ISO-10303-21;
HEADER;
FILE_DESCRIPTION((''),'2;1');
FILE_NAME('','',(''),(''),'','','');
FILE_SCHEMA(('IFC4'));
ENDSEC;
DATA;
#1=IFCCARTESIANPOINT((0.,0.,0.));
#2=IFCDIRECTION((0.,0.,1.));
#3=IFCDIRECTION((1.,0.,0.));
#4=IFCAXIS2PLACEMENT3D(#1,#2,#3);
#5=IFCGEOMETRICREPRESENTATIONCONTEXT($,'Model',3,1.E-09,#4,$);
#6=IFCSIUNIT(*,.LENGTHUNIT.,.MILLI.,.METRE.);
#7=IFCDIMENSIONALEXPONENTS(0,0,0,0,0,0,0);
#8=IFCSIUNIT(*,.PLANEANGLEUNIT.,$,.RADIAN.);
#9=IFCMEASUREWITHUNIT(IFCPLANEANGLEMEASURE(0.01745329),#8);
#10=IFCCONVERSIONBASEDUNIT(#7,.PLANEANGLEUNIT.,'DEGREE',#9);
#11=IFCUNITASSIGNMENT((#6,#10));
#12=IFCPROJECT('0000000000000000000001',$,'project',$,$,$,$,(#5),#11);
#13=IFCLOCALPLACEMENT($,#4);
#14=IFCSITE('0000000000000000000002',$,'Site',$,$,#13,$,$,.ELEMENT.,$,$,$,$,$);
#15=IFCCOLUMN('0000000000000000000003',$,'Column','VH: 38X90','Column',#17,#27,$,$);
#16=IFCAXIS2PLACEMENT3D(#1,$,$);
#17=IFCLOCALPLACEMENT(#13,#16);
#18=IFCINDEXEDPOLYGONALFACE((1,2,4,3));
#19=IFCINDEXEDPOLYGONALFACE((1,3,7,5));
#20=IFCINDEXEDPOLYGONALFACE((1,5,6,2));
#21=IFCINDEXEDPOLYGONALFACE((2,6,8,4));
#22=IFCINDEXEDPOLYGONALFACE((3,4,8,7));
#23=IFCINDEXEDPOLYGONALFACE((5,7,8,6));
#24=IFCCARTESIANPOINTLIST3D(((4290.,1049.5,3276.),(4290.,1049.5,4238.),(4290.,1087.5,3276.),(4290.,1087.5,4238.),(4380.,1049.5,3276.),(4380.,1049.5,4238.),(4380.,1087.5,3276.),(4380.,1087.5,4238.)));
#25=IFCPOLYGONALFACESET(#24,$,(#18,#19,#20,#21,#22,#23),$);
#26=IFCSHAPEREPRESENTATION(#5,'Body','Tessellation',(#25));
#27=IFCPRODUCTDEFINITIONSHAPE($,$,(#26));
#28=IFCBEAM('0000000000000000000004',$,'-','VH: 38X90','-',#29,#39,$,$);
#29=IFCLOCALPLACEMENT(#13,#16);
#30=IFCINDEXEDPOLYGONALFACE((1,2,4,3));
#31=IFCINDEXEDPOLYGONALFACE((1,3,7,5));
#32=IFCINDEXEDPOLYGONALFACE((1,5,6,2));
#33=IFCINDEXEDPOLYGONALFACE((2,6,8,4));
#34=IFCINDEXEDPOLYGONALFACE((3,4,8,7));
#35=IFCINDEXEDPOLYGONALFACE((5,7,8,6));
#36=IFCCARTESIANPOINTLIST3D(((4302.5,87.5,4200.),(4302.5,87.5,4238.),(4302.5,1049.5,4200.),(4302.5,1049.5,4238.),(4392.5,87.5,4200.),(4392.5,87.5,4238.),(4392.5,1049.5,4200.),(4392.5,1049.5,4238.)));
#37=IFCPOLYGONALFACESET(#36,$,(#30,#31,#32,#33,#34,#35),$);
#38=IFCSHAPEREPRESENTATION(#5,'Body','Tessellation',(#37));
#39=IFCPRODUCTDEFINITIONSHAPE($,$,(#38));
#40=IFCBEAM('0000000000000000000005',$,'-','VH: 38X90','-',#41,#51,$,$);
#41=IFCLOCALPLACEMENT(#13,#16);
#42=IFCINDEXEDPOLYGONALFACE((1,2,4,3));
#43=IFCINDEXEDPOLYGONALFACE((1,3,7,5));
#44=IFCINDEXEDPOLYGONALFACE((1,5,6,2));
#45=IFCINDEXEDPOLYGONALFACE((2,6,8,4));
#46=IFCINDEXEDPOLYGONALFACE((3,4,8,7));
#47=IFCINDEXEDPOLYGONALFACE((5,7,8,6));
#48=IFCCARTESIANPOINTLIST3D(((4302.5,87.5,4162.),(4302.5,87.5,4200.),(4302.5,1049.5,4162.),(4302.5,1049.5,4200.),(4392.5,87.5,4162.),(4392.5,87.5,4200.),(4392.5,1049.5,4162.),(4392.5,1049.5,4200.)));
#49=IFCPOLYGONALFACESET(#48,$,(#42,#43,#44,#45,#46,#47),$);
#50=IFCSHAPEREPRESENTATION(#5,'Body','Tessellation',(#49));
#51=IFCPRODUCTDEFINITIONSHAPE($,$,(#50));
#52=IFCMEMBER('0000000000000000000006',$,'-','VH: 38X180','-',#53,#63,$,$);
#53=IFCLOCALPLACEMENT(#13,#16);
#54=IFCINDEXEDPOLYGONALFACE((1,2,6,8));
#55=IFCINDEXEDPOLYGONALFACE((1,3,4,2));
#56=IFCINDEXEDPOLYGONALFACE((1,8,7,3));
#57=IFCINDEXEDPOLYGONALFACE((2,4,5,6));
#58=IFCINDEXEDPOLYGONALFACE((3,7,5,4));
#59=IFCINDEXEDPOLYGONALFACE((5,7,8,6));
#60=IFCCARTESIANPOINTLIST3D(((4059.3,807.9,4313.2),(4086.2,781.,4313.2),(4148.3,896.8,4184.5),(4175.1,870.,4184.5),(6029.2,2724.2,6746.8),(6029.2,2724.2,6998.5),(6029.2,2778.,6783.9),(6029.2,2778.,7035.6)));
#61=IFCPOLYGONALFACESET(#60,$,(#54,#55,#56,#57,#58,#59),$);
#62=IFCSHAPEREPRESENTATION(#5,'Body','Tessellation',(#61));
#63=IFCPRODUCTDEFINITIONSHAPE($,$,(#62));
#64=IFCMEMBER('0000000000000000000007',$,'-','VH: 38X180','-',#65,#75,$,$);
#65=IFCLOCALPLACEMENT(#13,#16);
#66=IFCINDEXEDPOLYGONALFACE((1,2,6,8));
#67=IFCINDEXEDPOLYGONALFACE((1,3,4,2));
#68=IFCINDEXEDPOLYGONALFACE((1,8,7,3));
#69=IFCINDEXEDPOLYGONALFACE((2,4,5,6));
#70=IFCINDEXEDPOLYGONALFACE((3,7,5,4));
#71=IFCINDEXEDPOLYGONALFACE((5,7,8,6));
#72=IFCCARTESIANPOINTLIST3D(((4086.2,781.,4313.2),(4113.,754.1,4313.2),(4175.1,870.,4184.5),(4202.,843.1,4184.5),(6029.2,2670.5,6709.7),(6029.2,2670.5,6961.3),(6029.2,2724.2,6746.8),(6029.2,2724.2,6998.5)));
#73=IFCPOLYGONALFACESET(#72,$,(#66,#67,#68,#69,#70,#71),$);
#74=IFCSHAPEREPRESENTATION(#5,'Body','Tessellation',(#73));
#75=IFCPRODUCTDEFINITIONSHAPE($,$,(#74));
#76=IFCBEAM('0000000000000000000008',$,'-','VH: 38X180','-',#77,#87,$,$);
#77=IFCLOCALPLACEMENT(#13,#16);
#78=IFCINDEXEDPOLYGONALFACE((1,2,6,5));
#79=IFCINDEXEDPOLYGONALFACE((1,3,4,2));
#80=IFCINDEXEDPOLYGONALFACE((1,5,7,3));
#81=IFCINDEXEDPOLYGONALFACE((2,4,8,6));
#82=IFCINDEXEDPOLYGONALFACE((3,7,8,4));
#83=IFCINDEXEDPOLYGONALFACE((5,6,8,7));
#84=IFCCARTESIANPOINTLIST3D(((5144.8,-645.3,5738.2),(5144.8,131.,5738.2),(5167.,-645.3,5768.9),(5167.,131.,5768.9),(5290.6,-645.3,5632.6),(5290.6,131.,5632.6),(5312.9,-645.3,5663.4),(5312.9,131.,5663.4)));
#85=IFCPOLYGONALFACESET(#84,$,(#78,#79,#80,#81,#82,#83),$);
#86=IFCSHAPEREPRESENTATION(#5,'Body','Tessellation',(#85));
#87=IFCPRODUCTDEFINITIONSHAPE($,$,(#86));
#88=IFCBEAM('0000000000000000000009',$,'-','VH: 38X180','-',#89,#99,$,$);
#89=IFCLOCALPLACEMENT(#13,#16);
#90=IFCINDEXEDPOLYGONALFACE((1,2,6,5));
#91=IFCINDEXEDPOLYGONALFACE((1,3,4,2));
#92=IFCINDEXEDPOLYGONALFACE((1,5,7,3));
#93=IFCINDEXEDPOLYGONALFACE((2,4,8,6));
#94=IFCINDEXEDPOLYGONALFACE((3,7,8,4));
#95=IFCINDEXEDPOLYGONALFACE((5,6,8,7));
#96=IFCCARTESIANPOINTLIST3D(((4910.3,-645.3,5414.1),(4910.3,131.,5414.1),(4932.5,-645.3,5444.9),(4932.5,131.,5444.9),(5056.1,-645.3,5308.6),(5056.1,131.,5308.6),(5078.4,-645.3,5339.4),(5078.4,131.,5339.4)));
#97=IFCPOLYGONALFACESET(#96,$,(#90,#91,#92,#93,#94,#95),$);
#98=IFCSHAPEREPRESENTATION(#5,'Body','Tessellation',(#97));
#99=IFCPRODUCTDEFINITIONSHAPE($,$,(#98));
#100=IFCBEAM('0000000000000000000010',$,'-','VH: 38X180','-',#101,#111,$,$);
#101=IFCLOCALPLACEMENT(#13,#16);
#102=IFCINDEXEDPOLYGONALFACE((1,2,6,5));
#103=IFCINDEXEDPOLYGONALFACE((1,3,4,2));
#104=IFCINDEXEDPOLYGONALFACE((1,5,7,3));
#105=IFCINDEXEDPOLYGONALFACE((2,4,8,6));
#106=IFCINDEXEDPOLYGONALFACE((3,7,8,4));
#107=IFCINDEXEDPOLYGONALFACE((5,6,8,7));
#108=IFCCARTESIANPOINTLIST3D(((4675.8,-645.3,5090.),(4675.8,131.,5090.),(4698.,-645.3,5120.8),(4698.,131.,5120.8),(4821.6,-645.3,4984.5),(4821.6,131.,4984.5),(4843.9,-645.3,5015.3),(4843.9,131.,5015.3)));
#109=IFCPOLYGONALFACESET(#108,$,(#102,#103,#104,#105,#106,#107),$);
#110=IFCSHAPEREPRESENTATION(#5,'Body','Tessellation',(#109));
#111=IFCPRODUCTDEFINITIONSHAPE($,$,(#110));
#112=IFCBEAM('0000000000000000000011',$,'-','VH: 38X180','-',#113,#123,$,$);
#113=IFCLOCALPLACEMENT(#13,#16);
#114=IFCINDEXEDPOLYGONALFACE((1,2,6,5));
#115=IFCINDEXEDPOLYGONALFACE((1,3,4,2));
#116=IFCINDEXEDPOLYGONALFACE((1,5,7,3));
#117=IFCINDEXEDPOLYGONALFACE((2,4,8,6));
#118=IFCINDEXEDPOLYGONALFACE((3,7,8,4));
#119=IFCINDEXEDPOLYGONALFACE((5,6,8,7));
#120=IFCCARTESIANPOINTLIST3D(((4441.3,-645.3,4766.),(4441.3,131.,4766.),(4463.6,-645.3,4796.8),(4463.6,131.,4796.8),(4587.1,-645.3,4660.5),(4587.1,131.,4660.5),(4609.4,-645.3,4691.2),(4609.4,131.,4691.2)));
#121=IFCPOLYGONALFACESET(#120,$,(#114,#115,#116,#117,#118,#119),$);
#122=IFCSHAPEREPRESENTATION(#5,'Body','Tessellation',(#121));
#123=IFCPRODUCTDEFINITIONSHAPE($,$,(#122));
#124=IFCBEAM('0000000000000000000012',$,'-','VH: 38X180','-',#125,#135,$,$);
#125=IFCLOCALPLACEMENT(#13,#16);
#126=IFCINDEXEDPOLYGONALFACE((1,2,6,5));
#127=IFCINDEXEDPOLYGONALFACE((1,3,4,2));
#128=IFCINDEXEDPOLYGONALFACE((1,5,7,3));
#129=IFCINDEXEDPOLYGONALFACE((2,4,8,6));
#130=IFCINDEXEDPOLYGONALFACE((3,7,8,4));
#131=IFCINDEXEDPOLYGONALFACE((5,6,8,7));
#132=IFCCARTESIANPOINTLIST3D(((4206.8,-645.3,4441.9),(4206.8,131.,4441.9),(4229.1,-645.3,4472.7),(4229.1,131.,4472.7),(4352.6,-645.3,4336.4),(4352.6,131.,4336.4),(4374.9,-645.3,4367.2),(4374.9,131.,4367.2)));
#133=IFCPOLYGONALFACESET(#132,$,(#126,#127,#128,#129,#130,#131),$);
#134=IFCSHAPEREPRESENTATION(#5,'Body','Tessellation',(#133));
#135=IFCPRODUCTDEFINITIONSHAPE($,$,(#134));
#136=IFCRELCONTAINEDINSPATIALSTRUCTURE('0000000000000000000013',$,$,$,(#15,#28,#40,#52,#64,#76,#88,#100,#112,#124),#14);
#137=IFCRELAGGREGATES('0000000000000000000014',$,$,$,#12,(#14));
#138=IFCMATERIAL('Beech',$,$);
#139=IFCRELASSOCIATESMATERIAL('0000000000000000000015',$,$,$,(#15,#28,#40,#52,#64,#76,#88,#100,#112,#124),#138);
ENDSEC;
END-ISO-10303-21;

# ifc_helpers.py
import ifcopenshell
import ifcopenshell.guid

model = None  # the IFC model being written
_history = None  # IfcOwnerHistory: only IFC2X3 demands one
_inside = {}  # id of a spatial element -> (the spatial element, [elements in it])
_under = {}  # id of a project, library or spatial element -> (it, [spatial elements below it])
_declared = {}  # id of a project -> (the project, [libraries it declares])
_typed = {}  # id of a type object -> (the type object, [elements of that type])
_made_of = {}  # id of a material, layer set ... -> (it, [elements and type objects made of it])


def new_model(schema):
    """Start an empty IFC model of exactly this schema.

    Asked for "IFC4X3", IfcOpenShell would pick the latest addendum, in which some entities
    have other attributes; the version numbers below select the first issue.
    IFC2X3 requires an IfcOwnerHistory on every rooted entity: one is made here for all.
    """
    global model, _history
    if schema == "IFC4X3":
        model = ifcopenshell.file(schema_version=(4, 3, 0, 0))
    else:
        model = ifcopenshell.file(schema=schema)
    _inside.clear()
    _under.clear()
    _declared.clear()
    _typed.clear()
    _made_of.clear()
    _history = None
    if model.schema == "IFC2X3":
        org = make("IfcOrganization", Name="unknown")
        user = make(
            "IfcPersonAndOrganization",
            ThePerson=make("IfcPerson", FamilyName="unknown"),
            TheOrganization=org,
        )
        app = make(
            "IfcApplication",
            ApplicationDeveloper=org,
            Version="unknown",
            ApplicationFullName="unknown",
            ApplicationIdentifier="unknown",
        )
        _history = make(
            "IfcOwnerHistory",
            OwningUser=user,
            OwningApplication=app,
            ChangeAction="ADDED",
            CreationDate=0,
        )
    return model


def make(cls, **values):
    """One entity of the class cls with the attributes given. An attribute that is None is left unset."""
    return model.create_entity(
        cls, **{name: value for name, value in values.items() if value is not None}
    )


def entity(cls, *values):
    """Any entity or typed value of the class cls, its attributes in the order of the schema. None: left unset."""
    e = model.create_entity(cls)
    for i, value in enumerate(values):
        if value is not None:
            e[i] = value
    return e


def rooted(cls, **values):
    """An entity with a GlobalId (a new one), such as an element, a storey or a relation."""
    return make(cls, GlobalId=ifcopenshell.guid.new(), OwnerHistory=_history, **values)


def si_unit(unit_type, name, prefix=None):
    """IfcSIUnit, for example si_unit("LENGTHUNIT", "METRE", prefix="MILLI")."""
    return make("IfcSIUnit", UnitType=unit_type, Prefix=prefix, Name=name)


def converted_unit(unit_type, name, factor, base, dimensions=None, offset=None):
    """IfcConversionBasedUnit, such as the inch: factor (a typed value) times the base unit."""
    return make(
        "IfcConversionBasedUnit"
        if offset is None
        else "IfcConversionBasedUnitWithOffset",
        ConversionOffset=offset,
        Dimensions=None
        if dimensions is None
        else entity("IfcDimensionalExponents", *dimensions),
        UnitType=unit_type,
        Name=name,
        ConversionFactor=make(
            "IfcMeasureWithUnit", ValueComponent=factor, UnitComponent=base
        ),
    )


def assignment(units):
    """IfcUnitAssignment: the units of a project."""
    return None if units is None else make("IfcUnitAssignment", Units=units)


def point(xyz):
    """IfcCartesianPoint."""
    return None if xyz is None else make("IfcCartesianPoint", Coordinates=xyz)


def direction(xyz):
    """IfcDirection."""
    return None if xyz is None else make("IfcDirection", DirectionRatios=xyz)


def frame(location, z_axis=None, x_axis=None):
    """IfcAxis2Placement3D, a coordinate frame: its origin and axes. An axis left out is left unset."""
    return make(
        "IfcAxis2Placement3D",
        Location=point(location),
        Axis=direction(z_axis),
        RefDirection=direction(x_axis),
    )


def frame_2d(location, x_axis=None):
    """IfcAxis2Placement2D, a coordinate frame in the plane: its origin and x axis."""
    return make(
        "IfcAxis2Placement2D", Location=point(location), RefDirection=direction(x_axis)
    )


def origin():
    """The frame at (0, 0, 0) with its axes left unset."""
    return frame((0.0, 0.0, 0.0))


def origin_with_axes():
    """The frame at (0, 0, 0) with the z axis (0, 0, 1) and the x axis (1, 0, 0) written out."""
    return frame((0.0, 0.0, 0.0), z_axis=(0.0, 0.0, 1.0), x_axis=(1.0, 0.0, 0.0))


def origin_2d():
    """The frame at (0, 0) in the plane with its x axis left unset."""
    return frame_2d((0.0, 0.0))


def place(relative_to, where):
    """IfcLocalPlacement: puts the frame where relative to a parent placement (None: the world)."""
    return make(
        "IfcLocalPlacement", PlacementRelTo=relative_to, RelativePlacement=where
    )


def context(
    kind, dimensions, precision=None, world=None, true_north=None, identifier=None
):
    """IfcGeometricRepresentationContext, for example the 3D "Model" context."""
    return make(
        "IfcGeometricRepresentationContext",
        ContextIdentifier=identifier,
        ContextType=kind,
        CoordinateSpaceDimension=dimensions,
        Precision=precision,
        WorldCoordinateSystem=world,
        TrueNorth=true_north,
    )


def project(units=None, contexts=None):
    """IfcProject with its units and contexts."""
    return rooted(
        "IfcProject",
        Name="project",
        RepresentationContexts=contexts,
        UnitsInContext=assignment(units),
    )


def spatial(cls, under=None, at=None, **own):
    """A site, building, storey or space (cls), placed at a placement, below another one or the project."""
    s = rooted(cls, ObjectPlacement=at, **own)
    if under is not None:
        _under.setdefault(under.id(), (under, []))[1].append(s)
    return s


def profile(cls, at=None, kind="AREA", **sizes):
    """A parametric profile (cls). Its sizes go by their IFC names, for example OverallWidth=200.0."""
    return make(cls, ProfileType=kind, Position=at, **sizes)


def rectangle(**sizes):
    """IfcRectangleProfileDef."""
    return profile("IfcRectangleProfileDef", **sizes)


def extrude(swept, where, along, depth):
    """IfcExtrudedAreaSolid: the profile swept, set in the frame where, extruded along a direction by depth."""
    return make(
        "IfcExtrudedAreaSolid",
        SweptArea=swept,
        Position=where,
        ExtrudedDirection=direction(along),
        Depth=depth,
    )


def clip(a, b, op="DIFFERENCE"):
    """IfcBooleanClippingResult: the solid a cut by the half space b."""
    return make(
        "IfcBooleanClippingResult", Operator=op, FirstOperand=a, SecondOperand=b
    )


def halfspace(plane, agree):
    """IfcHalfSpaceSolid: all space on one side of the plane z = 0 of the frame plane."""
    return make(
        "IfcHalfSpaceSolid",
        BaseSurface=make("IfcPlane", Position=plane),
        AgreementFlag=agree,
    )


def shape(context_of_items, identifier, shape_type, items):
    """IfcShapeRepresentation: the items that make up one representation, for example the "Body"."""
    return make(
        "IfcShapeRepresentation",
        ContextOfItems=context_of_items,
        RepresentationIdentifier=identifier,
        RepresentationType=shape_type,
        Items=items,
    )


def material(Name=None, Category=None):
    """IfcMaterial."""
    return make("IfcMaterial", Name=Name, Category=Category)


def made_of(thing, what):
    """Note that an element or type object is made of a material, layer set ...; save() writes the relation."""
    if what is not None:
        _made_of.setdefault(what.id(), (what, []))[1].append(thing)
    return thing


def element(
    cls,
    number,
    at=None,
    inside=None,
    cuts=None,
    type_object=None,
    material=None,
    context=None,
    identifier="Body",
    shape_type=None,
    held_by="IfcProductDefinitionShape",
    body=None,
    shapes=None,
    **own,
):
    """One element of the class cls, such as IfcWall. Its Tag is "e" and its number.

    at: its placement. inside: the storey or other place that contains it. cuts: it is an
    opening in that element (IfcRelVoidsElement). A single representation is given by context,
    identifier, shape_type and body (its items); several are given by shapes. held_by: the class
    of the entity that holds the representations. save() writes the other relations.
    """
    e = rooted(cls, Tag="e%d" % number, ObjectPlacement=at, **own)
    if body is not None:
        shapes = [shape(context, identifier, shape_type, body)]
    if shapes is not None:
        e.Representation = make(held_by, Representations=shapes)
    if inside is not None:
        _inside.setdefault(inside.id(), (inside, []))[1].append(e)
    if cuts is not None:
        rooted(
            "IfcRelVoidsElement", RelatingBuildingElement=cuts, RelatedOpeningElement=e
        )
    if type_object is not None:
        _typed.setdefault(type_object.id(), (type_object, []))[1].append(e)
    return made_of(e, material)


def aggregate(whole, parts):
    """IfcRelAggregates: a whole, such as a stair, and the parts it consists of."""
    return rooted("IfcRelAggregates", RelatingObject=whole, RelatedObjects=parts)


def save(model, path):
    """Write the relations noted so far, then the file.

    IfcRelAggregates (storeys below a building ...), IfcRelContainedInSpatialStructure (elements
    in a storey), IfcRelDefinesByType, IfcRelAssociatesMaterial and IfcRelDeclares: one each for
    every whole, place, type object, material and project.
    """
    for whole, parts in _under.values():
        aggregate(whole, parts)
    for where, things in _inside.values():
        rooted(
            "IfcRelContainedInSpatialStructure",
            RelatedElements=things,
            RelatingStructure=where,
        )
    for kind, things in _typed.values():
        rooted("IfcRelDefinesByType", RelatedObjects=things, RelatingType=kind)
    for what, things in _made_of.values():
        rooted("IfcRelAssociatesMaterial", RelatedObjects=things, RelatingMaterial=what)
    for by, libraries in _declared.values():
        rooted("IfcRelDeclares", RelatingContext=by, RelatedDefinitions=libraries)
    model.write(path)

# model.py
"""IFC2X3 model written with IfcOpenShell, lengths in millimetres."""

from ifc_helpers import new_model, entity, si_unit, converted_unit, frame, origin, origin_with_axes, origin_2d, place, context, project, spatial, rectangle, extrude, clip, halfspace, material, element, save


model = new_model("IFC2X3")

# Units and contexts
model_context = context("Model", 3, precision=1e-09, world=origin_with_axes())
ifc_project = project(units=[si_unit("LENGTHUNIT", "METRE", prefix="MILLI"), converted_unit("PLANEANGLEUNIT", "DEGREE", entity("IfcPlaneAngleMeasure", 0.01745329), si_unit("PLANEANGLEUNIT", "RADIAN"), dimensions=[0, 0, 0, 0, 0, 0, 0])], contexts=[model_context])

# Site
site_placement = place(None, origin_with_axes())
site = spatial("IfcSite", under=ifc_project, at=site_placement, Name="Site", CompositionType="ELEMENT")

# Column
ifc_material = material(Name="Beech")
column_1_placement = place(None, frame((4335.0, 1068.5, 3276.0), z_axis=(0.0, 0.0, -1.0), x_axis=(0.0, -1.0, 0.0)))
element("IfcColumn", 1, at=column_1_placement, inside=site, material=ifc_material, Name="Column", Description="VH: 38X90", ObjectType="Column", context=model_context, shape_type="SweptSolid", body=[
    extrude(rectangle(XDim=38.0, YDim=90.0, at=origin_2d()), origin(), (0.0, 0.0, -1.0), 962.0),
])

# Beams
for number, where, z_axis, x_axis, name in (
    (2, (4347.5, 87.5, 4219.0), (0.0, 1.0, 0.0), (0.0, 0.0, 1.0), "-"),
    (3, (4347.5, 87.5, 4181.0), (0.0, 1.0, 0.0), (0.0, 0.0, 1.0), "-"),
):
    element("IfcBeam", number, at=place(None, frame(where, z_axis=z_axis, x_axis=x_axis)), inside=site, material=ifc_material, Name=name, Description="VH: 38X90", ObjectType="-", context=model_context, shape_type="SweptSolid", body=[
        extrude(rectangle(XDim=38.0, YDim=90.0, at=origin_2d()), origin(), (0.0, 0.0, 1.0), 962.0),
    ])

# Members
member_1_placement = place(None, frame((4117.2, 838.9, 4248.9), z_axis=(0.505723, 0.505767, 0.698888), x_axis=(-0.707137, 0.707076, 0.0)))
element("IfcMember", 4, at=member_1_placement, inside=site, material=ifc_material, Name="-", Description="VH: 38X180", ObjectType="-", context=model_context, shape_type="Clipping", body=[
    clip(extrude(rectangle(XDim=38.0, YDim=180.0, at=origin_2d()), origin(), (0.0, 0.0, 1.0), 4351.8), halfspace(frame((-1945.2, -3569.2, -2426.8), z_axis=(0.707137, 0.494167, -0.505723), x_axis=(-0.707076, 0.494209, -0.505767)), True)),
])
member_2_placement = place(None, frame((4144.1, 812.1, 4248.9), z_axis=(0.505723, 0.505767, 0.698888), x_axis=(-0.707137, 0.707076, 0.0)))
element("IfcMember", 5, at=member_2_placement, inside=site, material=ifc_material, Name="-", Description="VH: 38X180", ObjectType="-", context=model_context, shape_type="Clipping", body=[
    clip(extrude(rectangle(XDim=38.0, YDim=180.0, at=origin_2d()), origin(), (0.0, 0.0, 1.0), 4351.8), halfspace(frame((-1907.2, -3569.2, -2426.8), z_axis=(0.707137, 0.494167, -0.505723), x_axis=(-0.707076, 0.494209, -0.505767)), True)),
])

# Beams
for number, where, z_axis, x_axis, name in (
    (6, (5228.8, 131.0, 5700.8), (0.0, 1.0, 0.0), (0.58623, 0.0, 0.810145), "-"),
    (7, (4994.3, 131.0, 5376.7), (0.0, 1.0, 0.0), (0.58623, 0.0, 0.810145), "-"),
    (8, (4759.8, 131.0, 5052.7), (0.0, 1.0, 0.0), (0.58623, 0.0, 0.810145), "-"),
    (9, (4525.3, 131.0, 4728.6), (0.0, 1.0, 0.0), (0.58623, 0.0, 0.810145), "-"),
    (10, (4290.8, 131.0, 4404.6), (0.0, 1.0, 0.0), (0.58623, 0.0, 0.810145), "-"),
):
    element("IfcBeam", number, at=place(None, frame(where, z_axis=z_axis, x_axis=x_axis)), inside=site, material=ifc_material, Name=name, Description="VH: 38X180", ObjectType="-", context=model_context, shape_type="SweptSolid", body=[
        extrude(rectangle(XDim=38.0, YDim=180.0, at=origin_2d()), origin(), (0.0, 0.0, -1.0), 776.3),
    ])

save(model, "model.ifc")
